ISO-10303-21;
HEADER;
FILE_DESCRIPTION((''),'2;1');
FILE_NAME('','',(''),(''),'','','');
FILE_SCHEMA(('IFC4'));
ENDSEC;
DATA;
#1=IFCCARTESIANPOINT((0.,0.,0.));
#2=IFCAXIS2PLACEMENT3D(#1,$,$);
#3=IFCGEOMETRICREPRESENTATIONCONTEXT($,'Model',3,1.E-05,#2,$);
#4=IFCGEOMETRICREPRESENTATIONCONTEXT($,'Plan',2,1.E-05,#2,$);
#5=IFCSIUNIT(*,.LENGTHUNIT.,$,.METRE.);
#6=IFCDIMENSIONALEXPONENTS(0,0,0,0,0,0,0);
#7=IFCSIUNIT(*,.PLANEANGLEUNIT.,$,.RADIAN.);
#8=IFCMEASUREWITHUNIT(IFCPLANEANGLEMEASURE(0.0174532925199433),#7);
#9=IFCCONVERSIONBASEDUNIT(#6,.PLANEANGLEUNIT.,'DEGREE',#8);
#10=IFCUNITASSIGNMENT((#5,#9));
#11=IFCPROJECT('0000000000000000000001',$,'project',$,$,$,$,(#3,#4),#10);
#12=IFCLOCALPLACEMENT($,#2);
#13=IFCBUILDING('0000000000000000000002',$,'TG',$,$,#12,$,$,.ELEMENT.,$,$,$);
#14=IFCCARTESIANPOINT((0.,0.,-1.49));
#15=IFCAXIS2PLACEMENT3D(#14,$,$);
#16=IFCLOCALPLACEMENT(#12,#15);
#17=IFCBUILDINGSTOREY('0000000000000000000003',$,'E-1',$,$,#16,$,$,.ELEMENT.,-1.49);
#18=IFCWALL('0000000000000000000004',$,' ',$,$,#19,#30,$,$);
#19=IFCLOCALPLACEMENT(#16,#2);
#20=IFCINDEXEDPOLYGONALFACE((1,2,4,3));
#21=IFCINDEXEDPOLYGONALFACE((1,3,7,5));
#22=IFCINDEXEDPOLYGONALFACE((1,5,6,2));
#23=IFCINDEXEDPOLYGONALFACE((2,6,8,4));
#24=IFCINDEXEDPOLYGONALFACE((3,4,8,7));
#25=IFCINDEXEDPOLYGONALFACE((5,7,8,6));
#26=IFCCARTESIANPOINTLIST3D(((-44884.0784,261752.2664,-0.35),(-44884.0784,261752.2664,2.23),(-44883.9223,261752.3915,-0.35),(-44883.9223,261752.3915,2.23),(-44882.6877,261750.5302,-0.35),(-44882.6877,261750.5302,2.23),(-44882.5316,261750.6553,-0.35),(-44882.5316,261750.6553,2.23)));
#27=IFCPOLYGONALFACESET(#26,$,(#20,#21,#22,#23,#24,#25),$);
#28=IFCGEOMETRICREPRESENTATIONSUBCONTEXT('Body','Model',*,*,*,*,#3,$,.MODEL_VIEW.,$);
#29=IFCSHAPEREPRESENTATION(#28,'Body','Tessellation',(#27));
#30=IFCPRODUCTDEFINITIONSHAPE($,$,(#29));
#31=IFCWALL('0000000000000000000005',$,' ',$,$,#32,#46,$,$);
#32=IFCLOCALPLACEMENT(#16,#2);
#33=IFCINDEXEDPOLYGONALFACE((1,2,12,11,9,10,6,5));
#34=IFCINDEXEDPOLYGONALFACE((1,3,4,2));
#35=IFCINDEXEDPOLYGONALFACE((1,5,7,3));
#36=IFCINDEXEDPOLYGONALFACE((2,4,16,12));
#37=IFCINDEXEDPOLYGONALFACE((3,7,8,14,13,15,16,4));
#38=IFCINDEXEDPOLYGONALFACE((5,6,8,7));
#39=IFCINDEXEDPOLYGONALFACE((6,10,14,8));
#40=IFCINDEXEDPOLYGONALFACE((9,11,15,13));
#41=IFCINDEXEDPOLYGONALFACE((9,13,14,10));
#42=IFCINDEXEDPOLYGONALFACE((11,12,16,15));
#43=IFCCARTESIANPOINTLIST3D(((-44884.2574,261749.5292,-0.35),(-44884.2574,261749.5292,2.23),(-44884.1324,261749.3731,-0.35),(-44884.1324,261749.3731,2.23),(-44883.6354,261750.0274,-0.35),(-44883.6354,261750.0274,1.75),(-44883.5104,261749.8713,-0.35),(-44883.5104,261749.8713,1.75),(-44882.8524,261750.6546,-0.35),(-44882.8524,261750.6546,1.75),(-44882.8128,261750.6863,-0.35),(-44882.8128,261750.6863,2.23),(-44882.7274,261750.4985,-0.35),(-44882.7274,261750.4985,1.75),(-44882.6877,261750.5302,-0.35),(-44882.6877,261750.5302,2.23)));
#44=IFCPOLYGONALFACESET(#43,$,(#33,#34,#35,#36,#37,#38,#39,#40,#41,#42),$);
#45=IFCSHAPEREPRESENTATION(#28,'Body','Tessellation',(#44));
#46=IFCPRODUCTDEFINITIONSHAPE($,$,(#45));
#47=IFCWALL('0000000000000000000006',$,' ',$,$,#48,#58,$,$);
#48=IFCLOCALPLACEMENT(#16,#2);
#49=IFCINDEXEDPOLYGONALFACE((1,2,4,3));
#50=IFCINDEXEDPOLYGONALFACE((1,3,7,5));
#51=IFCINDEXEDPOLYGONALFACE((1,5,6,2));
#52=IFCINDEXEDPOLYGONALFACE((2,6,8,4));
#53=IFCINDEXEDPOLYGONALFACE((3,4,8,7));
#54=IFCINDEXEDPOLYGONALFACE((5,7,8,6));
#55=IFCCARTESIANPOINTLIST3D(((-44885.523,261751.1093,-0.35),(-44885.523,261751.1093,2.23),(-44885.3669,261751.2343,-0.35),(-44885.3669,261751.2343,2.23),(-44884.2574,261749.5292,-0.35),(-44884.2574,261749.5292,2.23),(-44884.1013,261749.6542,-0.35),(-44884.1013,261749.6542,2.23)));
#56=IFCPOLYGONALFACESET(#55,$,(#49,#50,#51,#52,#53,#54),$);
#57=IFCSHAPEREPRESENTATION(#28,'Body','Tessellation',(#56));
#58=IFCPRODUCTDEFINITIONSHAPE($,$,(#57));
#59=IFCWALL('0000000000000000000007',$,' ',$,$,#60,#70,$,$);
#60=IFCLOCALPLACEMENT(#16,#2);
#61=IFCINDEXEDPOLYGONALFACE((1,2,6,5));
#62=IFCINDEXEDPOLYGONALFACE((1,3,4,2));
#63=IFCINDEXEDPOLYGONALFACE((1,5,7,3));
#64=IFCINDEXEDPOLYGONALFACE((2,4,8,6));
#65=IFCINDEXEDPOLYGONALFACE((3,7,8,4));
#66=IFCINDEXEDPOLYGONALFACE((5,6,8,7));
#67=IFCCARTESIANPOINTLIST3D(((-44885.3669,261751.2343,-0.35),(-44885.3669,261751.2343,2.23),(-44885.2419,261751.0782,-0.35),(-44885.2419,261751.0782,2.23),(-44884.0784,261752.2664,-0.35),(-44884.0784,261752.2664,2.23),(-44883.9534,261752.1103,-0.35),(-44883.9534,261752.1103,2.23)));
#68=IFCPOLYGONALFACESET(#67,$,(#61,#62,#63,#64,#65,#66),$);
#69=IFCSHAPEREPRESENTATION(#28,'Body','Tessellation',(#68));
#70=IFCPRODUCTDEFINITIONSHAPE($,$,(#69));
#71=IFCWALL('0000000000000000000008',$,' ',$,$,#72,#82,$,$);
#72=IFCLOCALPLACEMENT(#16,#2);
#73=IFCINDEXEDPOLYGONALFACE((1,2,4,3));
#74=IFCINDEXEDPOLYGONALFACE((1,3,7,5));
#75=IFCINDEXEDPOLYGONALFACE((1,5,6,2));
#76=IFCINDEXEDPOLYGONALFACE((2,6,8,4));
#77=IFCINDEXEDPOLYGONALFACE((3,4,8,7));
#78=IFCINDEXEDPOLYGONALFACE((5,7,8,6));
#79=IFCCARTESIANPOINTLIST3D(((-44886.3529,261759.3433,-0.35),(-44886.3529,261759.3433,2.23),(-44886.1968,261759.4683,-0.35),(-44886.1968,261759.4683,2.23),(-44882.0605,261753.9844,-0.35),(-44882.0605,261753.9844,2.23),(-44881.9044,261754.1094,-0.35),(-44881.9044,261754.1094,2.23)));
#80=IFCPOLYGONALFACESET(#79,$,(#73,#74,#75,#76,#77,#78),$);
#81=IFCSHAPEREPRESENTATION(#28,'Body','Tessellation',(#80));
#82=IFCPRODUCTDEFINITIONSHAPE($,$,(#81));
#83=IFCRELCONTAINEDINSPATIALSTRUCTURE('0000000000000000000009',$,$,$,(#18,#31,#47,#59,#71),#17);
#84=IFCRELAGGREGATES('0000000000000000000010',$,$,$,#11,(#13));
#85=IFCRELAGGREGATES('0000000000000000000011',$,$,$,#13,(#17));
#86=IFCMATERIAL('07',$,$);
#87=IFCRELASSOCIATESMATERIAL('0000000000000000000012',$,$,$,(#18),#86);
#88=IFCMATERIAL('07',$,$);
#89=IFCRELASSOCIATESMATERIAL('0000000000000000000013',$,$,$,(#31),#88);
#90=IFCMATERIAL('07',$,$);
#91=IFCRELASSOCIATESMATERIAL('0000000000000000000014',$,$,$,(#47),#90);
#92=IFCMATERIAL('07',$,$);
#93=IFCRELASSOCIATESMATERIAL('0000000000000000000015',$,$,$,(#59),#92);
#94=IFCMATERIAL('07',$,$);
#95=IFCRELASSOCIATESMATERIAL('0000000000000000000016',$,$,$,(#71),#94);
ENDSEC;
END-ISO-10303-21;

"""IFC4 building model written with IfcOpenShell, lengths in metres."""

from ifc_helpers import new_model, entity, si_unit, converted_unit, frame, frame_2d, origin, origin_with_axes, place, context, subcontext, project, spatial, polyline, rectangle, outline, extrude, material, element, save


model = new_model("IFC4")

# Units and contexts
model_context = context("Model", 3, precision=1e-05, world=origin())
plan_context = context("Plan", 2, precision=1e-05, world=origin())
body_context = subcontext(model_context, "Body", "Model", "MODEL_VIEW")
ifc_project = project(units=[si_unit("LENGTHUNIT", "METRE"), converted_unit("PLANEANGLEUNIT", "DEGREE", entity("IfcPlaneAngleMeasure", 0.0174532925199433), si_unit("PLANEANGLEUNIT", "RADIAN"), dimensions=[0, 0, 0, 0, 0, 0, 0])], contexts=[model_context, plan_context])

# Building, storey
building_placement = place(None, origin())
building = spatial("IfcBuilding", under=ifc_project, at=building_placement, Name="TG", CompositionType="ELEMENT")
storey_placement = place(building_placement, frame((0.0, 0.0, -1.49)))
storey = spatial("IfcBuildingStorey", under=building, at=storey_placement, Name="E-1", CompositionType="ELEMENT", Elevation=-1.49)

# Wall
ifc_material_1 = material(Name="07")
wall_1_placement = place(storey_placement, frame((-44884.0784, 261752.2664, -0.35), z_axis=(0.0, 0.0, 1.0), x_axis=(0.625159, -0.780498, 0.0)))
element("IfcWall", 1, at=wall_1_placement, inside=storey, material=ifc_material_1, Name=" ", context=body_context, shape_type="SweptSolid", body=[
    extrude(rectangle(XDim=2.2245, YDim=0.2, at=frame_2d((1.1122, 0.1), x_axis=(1.0, 0.0))), origin_with_axes(), (0.0, 0.0, 1.0), 2.58),
])

# Wall, opening
ifc_material_2 = material(Name="07")
wall_2_placement = place(storey_placement, frame((-44882.8128, 261750.6863, -0.35), z_axis=(0.0, 0.0, 1.0), x_axis=(-0.780498, -0.625159, 0.0)))
wall_2 = element("IfcWall", 2, at=wall_2_placement, inside=storey, material=ifc_material_2, Name=" ", context=body_context, shape_type="SweptSolid", body=[
    extrude(rectangle(XDim=1.8509, YDim=0.2, at=frame_2d((0.9255, 0.1), x_axis=(1.0, 0.0))), origin_with_axes(), (0.0, 0.0, 1.0), 2.58),
])
opening_1_placement = place(wall_2_placement, frame((1.0541, 0.2, 0.0), z_axis=(0.0, -1.0, 0.0), x_axis=(0.0, 0.0, 1.0)))
element("IfcOpeningElement", 3, at=opening_1_placement, cuts=wall_2, ObjectType="Opening", context=body_context, shape_type="SweptSolid", body=[
    extrude(outline(polyline([(0.0, 1.0033), (2.1, 1.0033), (2.1, 0.0), (0.0, 0.0), (0.0, 1.0033)])), origin_with_axes(), (0.0, 0.0, 1.0), 0.2),
])

# Walls
ifc_material_3 = material(Name="07")
wall_3_placement = place(storey_placement, frame((-44884.1013, 261749.6542, -0.35), z_axis=(0.0, 0.0, 1.0), x_axis=(-0.625159, 0.780498, 0.0)))
element("IfcWall", 4, at=wall_3_placement, inside=storey, material=ifc_material_3, Name=" ", context=body_context, shape_type="SweptSolid", body=[
    extrude(rectangle(XDim=2.0245, YDim=0.2, at=frame_2d((1.0122, 0.1), x_axis=(1.0, 0.0))), origin_with_axes(), (0.0, 0.0, 1.0), 2.58),
])
ifc_material_4 = material(Name="07")
wall_4_placement = place(storey_placement, frame((-44885.2419, 261751.0782, -0.35), z_axis=(0.0, 0.0, 1.0), x_axis=(0.780498, 0.625159, 0.0)))
element("IfcWall", 5, at=wall_4_placement, inside=storey, material=ifc_material_4, Name=" ", context=body_context, shape_type="SweptSolid", body=[
    extrude(rectangle(XDim=1.6509, YDim=0.2, at=frame_2d((0.8255, 0.1), x_axis=(1.0, 0.0))), origin_with_axes(), (0.0, 0.0, 1.0), 2.58),
])
ifc_material_5 = material(Name="07")
wall_5_placement = place(storey_placement, frame((-44881.9044, 261754.1094, -0.35), z_axis=(0.0, 0.0, 1.0), x_axis=(-0.625159, 0.780498, 0.0)))
element("IfcWall", 6, at=wall_5_placement, inside=storey, material=ifc_material_5, Name=" ", context=body_context, shape_type="SweptSolid", body=[
    extrude(rectangle(XDim=6.866, YDim=0.2, at=frame_2d((3.433, 0.1), x_axis=(1.0, 0.0))), origin_with_axes(), (0.0, 0.0, 1.0), 2.58),
])

save(model, "model.ifc")
